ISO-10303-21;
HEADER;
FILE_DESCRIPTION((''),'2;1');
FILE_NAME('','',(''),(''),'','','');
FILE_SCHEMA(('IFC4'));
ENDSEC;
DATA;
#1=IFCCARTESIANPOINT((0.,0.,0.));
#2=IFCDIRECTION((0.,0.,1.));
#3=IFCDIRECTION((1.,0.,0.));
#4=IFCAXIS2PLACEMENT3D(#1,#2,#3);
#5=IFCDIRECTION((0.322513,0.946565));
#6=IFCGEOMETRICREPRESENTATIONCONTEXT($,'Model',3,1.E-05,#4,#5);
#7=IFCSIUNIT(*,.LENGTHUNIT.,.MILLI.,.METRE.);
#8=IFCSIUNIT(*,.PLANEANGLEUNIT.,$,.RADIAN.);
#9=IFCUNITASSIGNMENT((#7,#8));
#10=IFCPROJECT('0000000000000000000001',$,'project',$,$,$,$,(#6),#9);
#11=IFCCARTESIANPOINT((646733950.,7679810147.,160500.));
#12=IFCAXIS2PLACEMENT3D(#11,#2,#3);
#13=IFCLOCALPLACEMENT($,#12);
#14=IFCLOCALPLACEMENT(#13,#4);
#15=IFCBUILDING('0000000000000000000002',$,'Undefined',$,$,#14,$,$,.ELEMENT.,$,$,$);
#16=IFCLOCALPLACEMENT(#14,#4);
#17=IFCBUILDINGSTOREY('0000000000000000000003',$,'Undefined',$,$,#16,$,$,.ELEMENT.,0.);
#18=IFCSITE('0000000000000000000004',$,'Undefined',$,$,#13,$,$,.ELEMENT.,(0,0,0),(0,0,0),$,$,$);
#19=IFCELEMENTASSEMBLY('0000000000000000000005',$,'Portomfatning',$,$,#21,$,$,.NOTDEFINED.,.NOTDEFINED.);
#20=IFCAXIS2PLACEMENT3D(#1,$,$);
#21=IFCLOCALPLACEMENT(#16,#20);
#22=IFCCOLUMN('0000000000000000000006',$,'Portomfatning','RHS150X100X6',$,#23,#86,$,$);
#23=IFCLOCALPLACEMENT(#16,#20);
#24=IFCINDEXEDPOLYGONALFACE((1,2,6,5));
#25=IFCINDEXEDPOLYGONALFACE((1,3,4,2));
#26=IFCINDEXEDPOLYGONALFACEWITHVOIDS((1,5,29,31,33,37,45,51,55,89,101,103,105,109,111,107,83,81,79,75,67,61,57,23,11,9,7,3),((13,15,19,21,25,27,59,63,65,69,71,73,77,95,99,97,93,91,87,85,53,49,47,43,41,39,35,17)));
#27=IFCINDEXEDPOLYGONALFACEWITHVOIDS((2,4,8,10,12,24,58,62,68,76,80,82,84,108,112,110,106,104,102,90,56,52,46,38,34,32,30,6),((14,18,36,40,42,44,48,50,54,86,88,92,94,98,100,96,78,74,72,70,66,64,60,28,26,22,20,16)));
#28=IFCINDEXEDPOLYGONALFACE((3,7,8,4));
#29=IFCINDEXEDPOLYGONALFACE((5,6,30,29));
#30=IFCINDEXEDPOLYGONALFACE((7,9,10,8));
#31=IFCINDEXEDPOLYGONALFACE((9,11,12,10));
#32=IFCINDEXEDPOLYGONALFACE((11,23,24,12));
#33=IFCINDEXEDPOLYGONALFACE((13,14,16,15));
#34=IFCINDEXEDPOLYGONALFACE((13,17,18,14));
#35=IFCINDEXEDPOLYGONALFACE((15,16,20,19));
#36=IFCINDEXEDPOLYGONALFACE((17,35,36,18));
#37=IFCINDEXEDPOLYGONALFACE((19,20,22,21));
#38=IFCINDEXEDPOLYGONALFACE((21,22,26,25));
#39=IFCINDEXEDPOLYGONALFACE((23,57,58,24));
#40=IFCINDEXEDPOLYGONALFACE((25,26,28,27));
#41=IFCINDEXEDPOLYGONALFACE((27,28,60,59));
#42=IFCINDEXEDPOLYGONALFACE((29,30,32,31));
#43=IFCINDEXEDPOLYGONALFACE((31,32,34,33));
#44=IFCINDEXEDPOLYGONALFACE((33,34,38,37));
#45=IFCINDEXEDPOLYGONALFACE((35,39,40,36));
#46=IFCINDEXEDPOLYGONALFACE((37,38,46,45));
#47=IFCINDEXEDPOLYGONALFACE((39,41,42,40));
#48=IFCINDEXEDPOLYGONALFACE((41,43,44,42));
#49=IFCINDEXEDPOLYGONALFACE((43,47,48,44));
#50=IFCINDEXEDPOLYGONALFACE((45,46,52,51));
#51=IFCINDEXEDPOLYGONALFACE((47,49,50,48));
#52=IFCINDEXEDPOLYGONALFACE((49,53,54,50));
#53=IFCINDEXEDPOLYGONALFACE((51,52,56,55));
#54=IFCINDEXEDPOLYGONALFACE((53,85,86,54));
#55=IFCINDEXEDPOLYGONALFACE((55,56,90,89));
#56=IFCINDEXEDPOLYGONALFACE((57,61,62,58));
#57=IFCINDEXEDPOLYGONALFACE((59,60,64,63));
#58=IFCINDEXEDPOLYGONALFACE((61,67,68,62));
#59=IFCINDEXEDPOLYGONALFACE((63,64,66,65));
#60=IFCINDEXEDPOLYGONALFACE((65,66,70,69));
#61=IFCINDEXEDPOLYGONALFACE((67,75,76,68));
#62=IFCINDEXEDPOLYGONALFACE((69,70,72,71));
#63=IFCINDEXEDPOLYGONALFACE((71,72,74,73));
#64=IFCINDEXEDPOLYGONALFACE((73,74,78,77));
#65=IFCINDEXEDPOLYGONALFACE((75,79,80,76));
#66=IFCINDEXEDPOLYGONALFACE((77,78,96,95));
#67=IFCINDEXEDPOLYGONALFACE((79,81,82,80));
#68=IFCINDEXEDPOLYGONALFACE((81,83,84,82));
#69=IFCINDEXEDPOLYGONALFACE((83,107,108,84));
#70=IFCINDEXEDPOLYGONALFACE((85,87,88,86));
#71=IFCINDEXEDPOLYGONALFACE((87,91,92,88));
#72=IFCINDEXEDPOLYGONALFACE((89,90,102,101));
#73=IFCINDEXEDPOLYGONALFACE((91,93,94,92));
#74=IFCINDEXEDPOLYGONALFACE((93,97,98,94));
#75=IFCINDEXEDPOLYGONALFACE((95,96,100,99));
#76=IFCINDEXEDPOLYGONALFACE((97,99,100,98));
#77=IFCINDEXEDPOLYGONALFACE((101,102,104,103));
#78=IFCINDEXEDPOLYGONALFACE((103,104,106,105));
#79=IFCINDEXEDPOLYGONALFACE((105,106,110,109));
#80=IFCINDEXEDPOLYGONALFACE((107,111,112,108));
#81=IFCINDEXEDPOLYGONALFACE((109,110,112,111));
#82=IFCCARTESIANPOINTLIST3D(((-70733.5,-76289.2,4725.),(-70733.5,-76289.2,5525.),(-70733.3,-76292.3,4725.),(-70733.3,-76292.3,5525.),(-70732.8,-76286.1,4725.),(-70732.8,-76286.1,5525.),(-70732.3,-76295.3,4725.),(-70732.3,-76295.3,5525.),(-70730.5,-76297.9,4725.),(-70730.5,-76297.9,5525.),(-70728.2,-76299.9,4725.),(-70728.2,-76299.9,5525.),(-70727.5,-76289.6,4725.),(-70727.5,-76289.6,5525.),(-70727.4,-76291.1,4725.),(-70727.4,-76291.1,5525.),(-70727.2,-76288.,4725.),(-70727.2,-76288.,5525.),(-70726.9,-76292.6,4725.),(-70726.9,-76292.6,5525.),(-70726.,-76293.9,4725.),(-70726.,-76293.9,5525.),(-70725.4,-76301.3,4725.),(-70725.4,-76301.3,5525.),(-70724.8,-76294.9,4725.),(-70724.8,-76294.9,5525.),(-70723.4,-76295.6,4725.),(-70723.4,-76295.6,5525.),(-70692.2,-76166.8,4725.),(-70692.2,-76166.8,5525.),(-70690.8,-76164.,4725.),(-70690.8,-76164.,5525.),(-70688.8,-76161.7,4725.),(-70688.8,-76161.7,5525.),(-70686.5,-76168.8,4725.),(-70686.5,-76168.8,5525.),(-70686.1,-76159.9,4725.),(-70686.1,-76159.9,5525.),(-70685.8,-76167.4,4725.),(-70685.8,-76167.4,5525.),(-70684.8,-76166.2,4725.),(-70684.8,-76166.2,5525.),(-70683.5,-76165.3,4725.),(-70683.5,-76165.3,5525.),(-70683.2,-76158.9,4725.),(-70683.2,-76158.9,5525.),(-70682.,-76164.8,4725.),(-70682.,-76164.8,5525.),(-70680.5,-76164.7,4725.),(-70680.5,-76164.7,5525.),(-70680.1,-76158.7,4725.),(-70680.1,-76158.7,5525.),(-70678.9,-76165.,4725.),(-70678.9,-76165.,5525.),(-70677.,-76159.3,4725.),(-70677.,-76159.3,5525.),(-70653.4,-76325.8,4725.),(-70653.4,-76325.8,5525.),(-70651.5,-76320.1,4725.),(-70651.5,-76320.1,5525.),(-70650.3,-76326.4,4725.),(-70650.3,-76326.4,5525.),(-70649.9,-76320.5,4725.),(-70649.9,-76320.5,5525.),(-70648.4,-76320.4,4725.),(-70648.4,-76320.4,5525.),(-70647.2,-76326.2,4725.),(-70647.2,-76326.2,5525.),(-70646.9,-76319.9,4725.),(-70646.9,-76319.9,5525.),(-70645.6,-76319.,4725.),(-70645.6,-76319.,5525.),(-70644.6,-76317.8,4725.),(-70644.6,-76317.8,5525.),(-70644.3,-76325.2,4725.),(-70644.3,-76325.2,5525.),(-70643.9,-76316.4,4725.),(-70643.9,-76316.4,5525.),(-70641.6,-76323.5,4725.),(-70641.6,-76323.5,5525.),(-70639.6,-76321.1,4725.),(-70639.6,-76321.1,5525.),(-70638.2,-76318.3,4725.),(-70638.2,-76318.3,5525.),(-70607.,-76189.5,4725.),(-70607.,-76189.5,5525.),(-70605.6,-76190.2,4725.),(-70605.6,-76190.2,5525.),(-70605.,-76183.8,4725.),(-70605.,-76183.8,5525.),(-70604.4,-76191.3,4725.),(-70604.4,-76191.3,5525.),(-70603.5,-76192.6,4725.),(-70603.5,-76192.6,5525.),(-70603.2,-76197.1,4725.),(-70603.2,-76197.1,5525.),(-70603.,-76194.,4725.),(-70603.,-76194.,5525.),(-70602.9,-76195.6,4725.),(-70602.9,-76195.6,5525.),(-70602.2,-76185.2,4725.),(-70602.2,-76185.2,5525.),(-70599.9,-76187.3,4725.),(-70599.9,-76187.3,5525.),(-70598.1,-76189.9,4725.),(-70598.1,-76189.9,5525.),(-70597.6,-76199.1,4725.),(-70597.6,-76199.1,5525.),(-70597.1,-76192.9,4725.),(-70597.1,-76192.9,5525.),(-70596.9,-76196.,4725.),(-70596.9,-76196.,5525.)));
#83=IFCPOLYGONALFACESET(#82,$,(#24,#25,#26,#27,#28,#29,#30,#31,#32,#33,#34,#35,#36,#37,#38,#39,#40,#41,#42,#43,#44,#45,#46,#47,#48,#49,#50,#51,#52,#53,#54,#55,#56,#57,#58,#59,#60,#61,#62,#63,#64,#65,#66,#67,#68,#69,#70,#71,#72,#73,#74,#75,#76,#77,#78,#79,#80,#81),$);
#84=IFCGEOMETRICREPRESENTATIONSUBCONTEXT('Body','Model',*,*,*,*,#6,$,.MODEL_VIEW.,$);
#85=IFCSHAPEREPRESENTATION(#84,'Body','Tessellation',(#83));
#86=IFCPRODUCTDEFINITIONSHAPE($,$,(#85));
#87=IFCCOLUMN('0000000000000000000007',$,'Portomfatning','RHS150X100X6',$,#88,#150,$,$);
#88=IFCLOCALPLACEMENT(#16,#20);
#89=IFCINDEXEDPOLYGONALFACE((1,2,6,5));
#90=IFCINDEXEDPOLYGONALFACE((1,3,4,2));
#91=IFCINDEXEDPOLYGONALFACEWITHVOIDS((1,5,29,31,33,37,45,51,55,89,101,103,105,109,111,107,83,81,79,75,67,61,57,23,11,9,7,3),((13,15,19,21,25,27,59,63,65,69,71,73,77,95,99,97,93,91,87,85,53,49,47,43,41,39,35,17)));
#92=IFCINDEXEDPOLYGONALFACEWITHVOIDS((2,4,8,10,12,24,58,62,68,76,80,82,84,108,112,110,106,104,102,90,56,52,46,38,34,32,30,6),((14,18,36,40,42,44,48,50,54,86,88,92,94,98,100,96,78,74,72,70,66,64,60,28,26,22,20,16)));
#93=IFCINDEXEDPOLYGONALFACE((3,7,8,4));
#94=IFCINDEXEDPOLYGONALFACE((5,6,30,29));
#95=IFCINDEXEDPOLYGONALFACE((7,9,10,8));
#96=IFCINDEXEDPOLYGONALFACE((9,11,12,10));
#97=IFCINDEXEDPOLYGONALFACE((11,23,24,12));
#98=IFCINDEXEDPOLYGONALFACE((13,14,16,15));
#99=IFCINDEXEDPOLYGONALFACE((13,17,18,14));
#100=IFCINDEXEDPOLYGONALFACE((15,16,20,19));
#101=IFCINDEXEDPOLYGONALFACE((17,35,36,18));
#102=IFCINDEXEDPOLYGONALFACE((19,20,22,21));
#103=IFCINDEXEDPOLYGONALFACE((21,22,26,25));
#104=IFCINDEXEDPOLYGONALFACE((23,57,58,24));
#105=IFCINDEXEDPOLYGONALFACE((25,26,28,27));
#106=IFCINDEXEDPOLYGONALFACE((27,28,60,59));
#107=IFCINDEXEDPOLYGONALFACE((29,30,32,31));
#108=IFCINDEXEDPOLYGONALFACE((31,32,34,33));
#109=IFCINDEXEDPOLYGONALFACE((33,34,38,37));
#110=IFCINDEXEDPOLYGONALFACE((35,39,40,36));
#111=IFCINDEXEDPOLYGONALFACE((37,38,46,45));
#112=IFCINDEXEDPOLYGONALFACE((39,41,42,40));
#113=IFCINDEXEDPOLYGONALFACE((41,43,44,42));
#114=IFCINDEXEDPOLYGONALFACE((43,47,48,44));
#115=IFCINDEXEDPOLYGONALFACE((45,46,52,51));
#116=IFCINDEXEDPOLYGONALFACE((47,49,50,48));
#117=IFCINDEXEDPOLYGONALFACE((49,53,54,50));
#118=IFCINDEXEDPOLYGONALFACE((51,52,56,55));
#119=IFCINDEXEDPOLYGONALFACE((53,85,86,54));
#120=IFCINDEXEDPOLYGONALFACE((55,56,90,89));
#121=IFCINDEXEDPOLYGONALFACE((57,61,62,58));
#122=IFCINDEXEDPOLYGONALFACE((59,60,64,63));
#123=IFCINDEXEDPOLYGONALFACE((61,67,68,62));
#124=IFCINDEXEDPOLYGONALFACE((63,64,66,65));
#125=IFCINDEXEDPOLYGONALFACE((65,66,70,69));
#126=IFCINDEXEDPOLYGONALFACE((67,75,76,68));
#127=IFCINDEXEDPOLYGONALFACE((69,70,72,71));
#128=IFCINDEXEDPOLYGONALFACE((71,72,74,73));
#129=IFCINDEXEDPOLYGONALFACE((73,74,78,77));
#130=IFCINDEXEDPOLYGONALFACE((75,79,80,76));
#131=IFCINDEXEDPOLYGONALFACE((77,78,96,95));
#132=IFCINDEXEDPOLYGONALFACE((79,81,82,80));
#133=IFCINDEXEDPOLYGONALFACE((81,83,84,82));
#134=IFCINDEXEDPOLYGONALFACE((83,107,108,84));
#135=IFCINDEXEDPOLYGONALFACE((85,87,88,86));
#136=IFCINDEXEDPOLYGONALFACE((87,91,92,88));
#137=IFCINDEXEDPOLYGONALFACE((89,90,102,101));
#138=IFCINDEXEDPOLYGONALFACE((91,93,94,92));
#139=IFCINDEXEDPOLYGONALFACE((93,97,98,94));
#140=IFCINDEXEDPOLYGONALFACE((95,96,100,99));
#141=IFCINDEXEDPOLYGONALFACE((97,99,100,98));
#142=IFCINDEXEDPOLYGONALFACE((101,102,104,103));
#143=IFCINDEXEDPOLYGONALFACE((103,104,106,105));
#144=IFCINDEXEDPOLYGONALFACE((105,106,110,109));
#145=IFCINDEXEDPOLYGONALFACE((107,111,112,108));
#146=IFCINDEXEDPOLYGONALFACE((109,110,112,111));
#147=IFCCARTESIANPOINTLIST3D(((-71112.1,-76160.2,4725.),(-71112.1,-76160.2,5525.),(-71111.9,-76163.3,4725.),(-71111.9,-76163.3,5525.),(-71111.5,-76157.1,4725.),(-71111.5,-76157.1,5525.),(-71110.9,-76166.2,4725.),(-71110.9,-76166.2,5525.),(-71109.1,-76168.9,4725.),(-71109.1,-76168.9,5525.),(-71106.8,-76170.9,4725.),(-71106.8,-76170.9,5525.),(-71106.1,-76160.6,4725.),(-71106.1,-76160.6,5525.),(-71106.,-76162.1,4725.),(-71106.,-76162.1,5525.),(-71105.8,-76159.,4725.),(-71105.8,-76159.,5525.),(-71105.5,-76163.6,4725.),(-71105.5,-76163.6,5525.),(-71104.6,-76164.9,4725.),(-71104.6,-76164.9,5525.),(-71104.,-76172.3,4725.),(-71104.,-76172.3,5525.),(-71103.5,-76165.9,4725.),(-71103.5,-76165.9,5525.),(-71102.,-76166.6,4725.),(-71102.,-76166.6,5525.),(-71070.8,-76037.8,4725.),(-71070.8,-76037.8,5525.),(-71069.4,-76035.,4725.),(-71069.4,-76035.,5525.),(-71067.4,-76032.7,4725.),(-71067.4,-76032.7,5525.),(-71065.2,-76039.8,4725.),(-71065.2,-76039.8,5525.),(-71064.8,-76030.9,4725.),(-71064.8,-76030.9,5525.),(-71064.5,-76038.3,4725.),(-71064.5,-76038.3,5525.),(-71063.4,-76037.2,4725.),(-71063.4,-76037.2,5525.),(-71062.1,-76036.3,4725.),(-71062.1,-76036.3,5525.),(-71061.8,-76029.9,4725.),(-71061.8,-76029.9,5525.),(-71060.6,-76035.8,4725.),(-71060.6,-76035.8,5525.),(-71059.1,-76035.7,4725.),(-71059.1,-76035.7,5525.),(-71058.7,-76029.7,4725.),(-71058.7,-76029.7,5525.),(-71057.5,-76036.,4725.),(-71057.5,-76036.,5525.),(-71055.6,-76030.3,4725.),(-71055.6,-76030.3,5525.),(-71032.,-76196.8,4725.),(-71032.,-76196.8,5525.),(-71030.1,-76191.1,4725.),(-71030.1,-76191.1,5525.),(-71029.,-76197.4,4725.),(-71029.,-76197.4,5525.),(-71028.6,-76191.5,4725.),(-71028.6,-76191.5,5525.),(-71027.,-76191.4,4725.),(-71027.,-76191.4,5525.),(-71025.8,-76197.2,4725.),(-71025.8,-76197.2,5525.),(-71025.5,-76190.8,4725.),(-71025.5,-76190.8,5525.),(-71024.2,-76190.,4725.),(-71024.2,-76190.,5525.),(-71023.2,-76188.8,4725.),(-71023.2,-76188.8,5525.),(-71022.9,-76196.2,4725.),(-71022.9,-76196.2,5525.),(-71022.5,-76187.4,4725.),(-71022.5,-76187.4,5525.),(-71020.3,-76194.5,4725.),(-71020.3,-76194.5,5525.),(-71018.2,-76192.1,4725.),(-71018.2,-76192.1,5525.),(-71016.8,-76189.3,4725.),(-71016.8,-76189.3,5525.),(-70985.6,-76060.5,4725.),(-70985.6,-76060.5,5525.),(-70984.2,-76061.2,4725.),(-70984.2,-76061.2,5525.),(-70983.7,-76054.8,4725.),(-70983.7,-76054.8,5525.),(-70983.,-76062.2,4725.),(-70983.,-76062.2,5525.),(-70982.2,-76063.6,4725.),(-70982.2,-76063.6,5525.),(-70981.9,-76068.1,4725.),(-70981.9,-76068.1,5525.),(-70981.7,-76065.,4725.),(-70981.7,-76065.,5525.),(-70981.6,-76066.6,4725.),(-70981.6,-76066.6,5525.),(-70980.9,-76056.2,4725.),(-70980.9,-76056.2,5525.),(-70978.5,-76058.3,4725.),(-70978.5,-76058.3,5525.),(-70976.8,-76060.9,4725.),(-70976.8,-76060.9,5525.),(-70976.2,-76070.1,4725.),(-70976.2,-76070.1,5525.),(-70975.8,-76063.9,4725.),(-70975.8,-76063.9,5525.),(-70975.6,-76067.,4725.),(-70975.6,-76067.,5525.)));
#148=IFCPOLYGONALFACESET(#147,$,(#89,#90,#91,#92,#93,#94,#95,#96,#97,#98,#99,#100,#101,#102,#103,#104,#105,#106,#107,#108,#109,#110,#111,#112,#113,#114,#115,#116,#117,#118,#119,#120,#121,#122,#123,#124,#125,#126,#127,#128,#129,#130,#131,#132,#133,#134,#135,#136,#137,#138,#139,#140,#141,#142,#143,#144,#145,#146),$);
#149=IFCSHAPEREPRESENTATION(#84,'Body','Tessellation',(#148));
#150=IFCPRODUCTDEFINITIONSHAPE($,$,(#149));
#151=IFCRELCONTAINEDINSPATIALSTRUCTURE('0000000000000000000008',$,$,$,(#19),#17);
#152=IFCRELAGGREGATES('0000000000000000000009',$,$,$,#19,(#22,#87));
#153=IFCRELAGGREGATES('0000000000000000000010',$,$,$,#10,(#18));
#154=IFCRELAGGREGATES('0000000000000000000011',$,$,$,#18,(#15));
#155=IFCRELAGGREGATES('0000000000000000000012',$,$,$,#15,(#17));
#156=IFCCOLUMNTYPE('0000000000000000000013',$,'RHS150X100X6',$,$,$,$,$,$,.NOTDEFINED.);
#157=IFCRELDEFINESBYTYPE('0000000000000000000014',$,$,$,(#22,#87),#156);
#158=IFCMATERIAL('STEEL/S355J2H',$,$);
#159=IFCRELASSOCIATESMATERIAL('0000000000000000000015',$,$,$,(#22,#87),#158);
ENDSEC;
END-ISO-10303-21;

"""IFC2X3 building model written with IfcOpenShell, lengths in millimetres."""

from ifc_helpers import new_model, si_unit, direction, frame, origin_with_axes, origin_2d_with_axis, place, context, subcontext, project, spatial, hollow_rectangle, extrude, material, type_object, element, aggregate, save


model = new_model("IFC2X3")

# Units and contexts
model_context = context("Model", 3, precision=1e-05, world=origin_with_axes(), true_north=direction((0.322513, 0.946565)))
body_context = subcontext(model_context, "Body", "Model", "MODEL_VIEW")
ifc_project = project(units=[si_unit("LENGTHUNIT", "METRE", prefix="MILLI"), si_unit("PLANEANGLEUNIT", "RADIAN")], contexts=[model_context])

# Site, building, storey
site_placement = place(None, frame((646733950.0, 7679810147.0, 160500.0), z_axis=(0.0, 0.0, 1.0), x_axis=(1.0, 0.0, 0.0)))
site = spatial("IfcSite", under=ifc_project, at=site_placement, Name="Undefined", CompositionType="ELEMENT", RefLatitude=(0, 0, 0), RefLongitude=(0, 0, 0))
building_placement = place(site_placement, origin_with_axes())
building = spatial("IfcBuilding", under=site, at=building_placement, Name="Undefined", CompositionType="ELEMENT")
storey_placement = place(building_placement, origin_with_axes())
storey = spatial("IfcBuildingStorey", under=building, at=storey_placement, Name="Undefined", CompositionType="ELEMENT", Elevation=0.0)

# Element assembly, columns
assembly_1_placement = place(storey_placement, origin_with_axes())
assembly_1 = element("IfcElementAssembly", 1, at=assembly_1_placement, inside=storey, Name="Portomfatning", AssemblyPlace="NOTDEFINED", PredefinedType="NOTDEFINED")
ifc_material_1 = material(Name="STEEL/S355J2H")
column_type_1 = type_object("IfcColumnType", Name="RHS150X100X6", PredefinedType="NOTDEFINED")
column_1_placement = place(assembly_1_placement, frame((-70665.2, -76242.6, 4725.0), z_axis=(0.0, 0.0, 1.0), x_axis=(-0.322513, -0.946565, 0.0)))
column_1 = element("IfcColumn", 2, at=column_1_placement, type_object=column_type_1, material=ifc_material_1, Name="Portomfatning", Description="RHS150X100X6", context=body_context, shape_type="SweptSolid", body=[
    extrude(hollow_rectangle(XDim=100.0, YDim=150.0, WallThickness=6.0, InnerFilletRadius=6.0, OuterFilletRadius=12.0, at=origin_2d_with_axis()), frame((0.0, 0.0, 800.0), z_axis=(0.0, 0.0, -1.0), x_axis=(0.0, 1.0, 0.0)), (0.0, 0.0, 1.0), 800.0),
])
column_2_placement = place(assembly_1_placement, frame((-71043.8, -76113.6, 4725.0), z_axis=(0.0, 0.0, 1.0), x_axis=(-0.322513, -0.946565, 0.0)))
column_2 = element("IfcColumn", 3, at=column_2_placement, type_object=column_type_1, material=ifc_material_1, Name="Portomfatning", Description="RHS150X100X6", context=body_context, shape_type="SweptSolid", body=[
    extrude(hollow_rectangle(XDim=100.0, YDim=150.0, WallThickness=6.0, InnerFilletRadius=6.0, OuterFilletRadius=12.0, at=origin_2d_with_axis()), frame((0.0, 0.0, 800.0), z_axis=(0.0, 0.0, -1.0), x_axis=(0.0, 1.0, 0.0)), (0.0, 0.0, 1.0), 800.0),
])

aggregate(assembly_1, [column_1, column_2])

save(model, "model.ifc")
